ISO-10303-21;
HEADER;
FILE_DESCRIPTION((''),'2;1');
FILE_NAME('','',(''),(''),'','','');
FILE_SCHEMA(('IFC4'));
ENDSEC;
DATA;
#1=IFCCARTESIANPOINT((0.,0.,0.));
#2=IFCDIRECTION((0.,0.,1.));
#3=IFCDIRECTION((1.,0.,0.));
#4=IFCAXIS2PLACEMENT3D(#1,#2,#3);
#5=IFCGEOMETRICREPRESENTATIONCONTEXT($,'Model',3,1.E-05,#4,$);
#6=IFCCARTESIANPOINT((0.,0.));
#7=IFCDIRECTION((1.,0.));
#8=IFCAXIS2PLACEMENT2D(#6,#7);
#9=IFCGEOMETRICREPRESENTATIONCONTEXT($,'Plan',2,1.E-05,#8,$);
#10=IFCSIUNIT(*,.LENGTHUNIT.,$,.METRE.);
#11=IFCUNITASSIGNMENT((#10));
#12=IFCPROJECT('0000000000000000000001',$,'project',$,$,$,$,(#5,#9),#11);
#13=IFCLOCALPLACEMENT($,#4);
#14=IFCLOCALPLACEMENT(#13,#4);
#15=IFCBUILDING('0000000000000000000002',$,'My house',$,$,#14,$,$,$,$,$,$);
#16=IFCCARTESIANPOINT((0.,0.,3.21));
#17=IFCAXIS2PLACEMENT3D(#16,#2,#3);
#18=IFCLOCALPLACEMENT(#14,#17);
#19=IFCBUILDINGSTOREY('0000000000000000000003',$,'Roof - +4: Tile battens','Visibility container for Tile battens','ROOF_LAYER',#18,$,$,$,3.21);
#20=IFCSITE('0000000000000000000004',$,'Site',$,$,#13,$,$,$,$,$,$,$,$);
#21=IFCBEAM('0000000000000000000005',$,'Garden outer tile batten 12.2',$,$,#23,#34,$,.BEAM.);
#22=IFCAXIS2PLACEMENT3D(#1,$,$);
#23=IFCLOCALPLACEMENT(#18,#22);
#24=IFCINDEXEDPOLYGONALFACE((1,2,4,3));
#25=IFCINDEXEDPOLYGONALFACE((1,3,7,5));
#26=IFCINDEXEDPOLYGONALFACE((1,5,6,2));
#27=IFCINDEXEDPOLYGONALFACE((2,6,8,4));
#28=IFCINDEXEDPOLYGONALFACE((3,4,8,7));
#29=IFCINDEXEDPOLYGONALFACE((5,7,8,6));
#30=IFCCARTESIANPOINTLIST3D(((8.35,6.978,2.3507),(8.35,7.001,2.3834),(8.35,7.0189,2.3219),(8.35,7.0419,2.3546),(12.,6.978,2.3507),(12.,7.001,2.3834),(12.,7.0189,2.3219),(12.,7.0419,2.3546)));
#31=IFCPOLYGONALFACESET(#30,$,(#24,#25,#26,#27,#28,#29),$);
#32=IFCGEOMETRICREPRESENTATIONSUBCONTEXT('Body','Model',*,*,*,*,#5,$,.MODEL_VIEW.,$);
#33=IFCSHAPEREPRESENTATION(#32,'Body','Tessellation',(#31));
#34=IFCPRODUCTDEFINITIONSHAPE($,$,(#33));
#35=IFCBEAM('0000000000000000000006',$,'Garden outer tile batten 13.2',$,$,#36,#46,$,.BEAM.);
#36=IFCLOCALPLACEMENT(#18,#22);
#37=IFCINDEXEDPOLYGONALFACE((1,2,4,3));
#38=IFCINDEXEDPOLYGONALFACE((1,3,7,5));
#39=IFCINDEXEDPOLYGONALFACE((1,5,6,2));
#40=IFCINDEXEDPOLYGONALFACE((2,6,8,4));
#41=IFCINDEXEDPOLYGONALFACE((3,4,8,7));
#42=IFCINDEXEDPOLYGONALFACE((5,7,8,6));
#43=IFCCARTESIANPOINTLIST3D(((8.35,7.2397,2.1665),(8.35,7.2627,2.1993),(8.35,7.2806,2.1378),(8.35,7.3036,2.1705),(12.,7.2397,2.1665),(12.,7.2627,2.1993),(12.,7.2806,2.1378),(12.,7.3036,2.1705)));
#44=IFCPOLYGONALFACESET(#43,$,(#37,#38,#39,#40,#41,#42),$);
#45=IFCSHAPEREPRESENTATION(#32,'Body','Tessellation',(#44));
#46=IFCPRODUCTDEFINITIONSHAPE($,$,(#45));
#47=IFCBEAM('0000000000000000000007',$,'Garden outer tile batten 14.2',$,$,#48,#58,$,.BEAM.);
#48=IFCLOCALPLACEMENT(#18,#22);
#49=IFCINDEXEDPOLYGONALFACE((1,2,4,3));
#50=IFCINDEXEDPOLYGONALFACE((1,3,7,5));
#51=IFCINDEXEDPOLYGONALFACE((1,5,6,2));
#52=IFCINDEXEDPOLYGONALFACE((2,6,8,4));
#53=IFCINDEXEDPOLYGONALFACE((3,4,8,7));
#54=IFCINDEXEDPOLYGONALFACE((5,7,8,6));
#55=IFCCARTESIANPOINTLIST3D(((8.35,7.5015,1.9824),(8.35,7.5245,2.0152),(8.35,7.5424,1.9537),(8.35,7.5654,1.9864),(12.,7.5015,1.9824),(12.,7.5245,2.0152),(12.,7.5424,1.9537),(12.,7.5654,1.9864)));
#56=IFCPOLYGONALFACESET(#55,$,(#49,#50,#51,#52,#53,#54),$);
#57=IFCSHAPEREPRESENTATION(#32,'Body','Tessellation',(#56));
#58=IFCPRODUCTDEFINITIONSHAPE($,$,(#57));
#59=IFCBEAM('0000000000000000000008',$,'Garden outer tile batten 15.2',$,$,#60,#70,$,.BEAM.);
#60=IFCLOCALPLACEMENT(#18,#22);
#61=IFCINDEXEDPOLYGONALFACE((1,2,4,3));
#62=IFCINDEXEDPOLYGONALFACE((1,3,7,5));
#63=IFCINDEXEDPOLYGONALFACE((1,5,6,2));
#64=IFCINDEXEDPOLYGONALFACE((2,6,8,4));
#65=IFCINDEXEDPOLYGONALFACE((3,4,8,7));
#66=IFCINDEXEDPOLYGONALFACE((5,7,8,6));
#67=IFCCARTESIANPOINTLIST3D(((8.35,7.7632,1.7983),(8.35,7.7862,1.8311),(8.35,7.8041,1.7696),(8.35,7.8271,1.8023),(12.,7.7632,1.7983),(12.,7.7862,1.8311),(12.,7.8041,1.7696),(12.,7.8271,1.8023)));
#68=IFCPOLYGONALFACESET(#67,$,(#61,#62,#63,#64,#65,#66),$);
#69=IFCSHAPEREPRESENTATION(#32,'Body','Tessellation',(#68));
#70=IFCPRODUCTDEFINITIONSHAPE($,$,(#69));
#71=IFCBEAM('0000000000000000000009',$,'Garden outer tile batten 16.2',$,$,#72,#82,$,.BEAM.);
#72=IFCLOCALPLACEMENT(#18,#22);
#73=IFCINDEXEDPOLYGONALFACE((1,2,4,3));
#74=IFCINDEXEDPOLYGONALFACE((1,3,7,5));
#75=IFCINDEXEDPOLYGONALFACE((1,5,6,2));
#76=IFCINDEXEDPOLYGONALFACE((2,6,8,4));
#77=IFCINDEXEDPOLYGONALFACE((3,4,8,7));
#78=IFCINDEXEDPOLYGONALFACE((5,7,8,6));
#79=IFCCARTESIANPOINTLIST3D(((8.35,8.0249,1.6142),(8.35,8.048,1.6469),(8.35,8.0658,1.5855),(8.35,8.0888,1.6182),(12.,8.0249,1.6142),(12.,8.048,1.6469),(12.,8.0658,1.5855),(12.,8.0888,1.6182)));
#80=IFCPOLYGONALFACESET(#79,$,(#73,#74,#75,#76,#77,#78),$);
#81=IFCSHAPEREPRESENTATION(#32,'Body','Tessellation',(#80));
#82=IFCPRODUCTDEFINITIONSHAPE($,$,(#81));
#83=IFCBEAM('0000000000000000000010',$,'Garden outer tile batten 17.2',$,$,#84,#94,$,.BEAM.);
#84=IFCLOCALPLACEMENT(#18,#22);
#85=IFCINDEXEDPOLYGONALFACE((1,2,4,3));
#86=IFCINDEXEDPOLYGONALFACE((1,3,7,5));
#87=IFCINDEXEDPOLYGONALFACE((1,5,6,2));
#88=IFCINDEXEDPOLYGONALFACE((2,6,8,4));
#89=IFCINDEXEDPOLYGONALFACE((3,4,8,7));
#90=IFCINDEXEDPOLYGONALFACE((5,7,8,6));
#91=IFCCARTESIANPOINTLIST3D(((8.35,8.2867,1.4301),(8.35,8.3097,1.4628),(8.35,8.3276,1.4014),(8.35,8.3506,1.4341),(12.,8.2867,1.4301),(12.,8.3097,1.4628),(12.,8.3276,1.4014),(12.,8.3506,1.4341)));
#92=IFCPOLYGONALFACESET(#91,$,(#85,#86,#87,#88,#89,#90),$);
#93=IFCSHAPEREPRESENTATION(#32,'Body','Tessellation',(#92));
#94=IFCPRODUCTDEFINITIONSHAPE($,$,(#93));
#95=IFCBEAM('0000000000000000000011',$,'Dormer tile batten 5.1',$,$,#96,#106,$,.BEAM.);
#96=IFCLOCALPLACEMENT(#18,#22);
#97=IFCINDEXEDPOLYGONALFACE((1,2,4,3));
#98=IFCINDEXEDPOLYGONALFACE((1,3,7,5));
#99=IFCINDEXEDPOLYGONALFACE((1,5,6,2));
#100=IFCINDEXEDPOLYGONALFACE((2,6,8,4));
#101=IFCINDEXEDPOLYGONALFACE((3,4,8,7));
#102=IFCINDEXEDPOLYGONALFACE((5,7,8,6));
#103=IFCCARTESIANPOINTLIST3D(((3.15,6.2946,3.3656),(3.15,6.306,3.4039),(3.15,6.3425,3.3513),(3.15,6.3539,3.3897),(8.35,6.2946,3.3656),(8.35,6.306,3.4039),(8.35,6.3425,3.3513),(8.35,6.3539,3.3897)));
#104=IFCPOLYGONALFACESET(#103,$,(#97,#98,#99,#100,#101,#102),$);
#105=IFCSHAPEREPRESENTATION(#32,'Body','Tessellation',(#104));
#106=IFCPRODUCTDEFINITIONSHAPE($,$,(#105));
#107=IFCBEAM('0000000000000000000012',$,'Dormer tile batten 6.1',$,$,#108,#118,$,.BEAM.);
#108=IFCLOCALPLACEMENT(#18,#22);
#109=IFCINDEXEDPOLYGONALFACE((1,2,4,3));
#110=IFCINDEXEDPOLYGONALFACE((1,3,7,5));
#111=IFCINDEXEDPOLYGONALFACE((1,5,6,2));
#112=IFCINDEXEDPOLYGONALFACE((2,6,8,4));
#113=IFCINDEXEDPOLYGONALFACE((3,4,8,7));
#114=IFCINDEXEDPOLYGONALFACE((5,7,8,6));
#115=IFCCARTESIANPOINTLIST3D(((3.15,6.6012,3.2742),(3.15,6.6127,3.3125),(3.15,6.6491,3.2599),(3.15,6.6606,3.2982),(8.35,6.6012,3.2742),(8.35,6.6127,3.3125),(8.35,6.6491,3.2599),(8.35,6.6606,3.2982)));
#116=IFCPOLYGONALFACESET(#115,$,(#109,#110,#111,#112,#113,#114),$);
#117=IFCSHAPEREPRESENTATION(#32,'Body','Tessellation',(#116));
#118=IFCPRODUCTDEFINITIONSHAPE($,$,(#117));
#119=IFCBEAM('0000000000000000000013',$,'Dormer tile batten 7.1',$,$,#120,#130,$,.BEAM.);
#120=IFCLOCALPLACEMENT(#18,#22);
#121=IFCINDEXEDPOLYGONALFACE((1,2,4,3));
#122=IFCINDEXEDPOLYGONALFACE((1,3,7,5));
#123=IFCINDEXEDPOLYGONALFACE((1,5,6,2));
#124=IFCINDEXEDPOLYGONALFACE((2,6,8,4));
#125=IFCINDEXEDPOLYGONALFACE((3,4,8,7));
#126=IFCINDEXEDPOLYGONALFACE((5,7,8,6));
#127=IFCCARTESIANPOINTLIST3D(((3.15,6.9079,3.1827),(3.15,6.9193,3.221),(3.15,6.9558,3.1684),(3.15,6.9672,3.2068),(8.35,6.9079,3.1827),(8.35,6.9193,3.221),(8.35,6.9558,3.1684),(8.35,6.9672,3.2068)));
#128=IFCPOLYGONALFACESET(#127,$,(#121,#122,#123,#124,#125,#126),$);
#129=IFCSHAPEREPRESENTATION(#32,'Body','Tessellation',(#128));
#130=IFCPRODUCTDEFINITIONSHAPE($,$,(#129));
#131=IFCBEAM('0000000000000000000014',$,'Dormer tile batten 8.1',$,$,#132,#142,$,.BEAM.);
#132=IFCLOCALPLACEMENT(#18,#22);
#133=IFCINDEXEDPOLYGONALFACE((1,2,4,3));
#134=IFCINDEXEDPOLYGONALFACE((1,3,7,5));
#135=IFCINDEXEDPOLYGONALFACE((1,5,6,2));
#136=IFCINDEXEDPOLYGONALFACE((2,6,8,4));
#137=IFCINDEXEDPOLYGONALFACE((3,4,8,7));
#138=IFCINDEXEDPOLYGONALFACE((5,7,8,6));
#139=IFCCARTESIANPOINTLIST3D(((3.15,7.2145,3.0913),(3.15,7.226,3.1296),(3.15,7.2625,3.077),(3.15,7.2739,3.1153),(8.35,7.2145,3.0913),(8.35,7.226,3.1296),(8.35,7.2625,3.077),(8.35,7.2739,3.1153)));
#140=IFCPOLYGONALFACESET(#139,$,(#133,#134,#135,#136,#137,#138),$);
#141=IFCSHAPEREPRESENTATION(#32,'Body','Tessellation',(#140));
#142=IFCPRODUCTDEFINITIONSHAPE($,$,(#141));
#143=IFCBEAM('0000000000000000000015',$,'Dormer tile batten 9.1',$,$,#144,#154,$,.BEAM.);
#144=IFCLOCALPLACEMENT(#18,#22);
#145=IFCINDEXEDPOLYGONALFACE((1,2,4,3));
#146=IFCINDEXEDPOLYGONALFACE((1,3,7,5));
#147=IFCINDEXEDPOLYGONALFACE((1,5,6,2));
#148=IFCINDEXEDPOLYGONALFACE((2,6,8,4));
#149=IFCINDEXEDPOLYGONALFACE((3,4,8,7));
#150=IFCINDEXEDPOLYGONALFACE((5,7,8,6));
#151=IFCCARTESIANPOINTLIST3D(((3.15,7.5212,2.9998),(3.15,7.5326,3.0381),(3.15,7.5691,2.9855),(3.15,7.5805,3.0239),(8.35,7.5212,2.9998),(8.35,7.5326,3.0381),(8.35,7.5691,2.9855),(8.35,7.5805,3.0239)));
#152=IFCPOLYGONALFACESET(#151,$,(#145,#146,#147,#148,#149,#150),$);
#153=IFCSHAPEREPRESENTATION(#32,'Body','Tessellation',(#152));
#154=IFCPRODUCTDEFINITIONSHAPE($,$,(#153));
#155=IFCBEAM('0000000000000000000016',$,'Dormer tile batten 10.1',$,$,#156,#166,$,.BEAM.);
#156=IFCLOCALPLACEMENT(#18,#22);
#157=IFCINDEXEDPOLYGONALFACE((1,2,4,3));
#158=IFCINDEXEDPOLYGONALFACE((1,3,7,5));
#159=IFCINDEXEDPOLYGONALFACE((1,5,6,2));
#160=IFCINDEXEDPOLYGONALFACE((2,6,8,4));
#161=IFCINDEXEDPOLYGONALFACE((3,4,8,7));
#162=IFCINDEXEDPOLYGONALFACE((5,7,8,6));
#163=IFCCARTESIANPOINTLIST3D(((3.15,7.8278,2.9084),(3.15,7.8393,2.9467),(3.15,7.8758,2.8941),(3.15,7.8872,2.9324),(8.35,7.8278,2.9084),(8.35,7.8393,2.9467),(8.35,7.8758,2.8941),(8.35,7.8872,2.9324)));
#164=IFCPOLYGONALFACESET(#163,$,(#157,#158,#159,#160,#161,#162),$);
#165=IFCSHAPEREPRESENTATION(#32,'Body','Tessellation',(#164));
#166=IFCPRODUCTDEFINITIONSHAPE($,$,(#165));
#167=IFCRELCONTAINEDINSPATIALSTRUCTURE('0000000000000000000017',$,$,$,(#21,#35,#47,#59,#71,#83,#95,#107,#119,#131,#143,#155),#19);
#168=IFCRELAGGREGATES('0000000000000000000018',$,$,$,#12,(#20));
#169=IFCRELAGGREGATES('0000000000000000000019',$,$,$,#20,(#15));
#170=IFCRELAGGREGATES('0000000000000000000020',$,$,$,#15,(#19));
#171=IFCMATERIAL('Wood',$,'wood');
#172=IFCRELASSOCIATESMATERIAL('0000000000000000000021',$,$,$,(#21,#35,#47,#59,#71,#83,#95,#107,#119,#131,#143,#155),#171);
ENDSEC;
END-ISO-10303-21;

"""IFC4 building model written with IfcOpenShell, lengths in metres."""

from ifc_helpers import new_model, si_unit, frame, origin_with_axes, origin_2d_with_axis, place, context, subcontext, project, spatial, rectangle, extrude, clip, halfspace, material, element, save


model = new_model("IFC4")

# Units and contexts
model_context = context("Model", 3, precision=1e-05, world=origin_with_axes())
plan_context = context("Plan", 2, precision=1e-05, world=origin_2d_with_axis())
body_context = subcontext(model_context, "Body", "Model", "MODEL_VIEW")
ifc_project = project(units=[si_unit("LENGTHUNIT", "METRE")], contexts=[model_context, plan_context])

# Site, building, storey
site_placement = place(None, origin_with_axes())
site = spatial("IfcSite", under=ifc_project, at=site_placement, Name="Site")
building_placement = place(site_placement, origin_with_axes())
building = spatial("IfcBuilding", under=site, at=building_placement, Name="My house")
storey_placement = place(building_placement, frame((0.0, 0.0, 3.21), z_axis=(0.0, 0.0, 1.0), x_axis=(1.0, 0.0, 0.0)))
storey = spatial("IfcBuildingStorey", under=building, at=storey_placement, Name="Roof - +4: Tile battens", Description="Visibility container for Tile battens", ObjectType="ROOF_LAYER", Elevation=3.21)

# Beams
ifc_material = material(Name="Wood", Category="wood")
beam_1_placement = place(storey_placement, frame((8.35, 7.01, 2.3526), z_axis=(0.0, 0.575329, 0.817922), x_axis=(1.0, 0.0, 0.0)))
element("IfcBeam", 1, at=beam_1_placement, inside=storey, material=ifc_material, Name="Garden outer tile batten 12.2", PredefinedType="BEAM", context=body_context, shape_type="Clipping", body=[
    clip(clip(extrude(rectangle(XDim=0.05, YDim=0.04), frame((0.0, 0.0, 0.0), z_axis=(1.0, 0.0, 0.0), x_axis=(0.0, 1.0, 0.0)), (0.0, 0.0, 1.0), 3.65), halfspace(frame((-8.35, 0.7384, -6.2815), z_axis=(0.0, -0.817922, -0.575329), x_axis=(-1.0, 0.0, 0.0)), False)), halfspace(frame((-8.35, 4.3373, -3.7501), z_axis=(0.0, 0.817922, 0.575329), x_axis=(1.0, 0.0, 0.0)), False)),
])
beam_2_placement = place(storey_placement, frame((8.35, 7.2717, 2.1685), z_axis=(0.0, 0.575329, 0.817922), x_axis=(1.0, 0.0, 0.0)))
element("IfcBeam", 2, at=beam_2_placement, inside=storey, material=ifc_material, Name="Garden outer tile batten 13.2", PredefinedType="BEAM", context=body_context, shape_type="Clipping", body=[
    clip(clip(extrude(rectangle(XDim=0.05, YDim=0.04), frame((0.0, 0.0, 0.0), z_axis=(1.0, 0.0, 0.0), x_axis=(0.0, 1.0, 0.0)), (0.0, 0.0, 1.0), 3.65), halfspace(frame((-8.35, 0.4184, -6.2815), z_axis=(0.0, -0.817922, -0.575329), x_axis=(-1.0, 0.0, 0.0)), False)), halfspace(frame((-8.35, 4.0173, -3.7501), z_axis=(0.0, 0.817922, 0.575329), x_axis=(1.0, 0.0, 0.0)), False)),
])
beam_3_placement = place(storey_placement, frame((8.35, 7.5334, 1.9844), z_axis=(0.0, 0.575329, 0.817922), x_axis=(1.0, 0.0, 0.0)))
element("IfcBeam", 3, at=beam_3_placement, inside=storey, material=ifc_material, Name="Garden outer tile batten 14.2", PredefinedType="BEAM", context=body_context, shape_type="Clipping", body=[
    clip(clip(extrude(rectangle(XDim=0.05, YDim=0.04), frame((0.0, 0.0, 0.0), z_axis=(1.0, 0.0, 0.0), x_axis=(0.0, 1.0, 0.0)), (0.0, 0.0, 1.0), 3.65), halfspace(frame((-8.35, 0.0984, -6.2815), z_axis=(0.0, -0.817922, -0.575329), x_axis=(-1.0, 0.0, 0.0)), False)), halfspace(frame((-8.35, 3.6973, -3.7501), z_axis=(0.0, 0.817922, 0.575329), x_axis=(1.0, 0.0, 0.0)), False)),
])
beam_4_placement = place(storey_placement, frame((8.35, 7.7952, 1.8003), z_axis=(0.0, 0.575329, 0.817922), x_axis=(1.0, 0.0, 0.0)))
element("IfcBeam", 4, at=beam_4_placement, inside=storey, material=ifc_material, Name="Garden outer tile batten 15.2", PredefinedType="BEAM", context=body_context, shape_type="Clipping", body=[
    clip(clip(extrude(rectangle(XDim=0.05, YDim=0.04), frame((0.0, 0.0, 0.0), z_axis=(1.0, 0.0, 0.0), x_axis=(0.0, 1.0, 0.0)), (0.0, 0.0, 1.0), 3.65), halfspace(frame((-8.35, -0.2216, -6.2815), z_axis=(0.0, -0.817922, -0.575329), x_axis=(-1.0, 0.0, 0.0)), False)), halfspace(frame((-8.35, 3.3773, -3.7501), z_axis=(0.0, 0.817922, 0.575329), x_axis=(1.0, 0.0, 0.0)), False)),
])
beam_5_placement = place(storey_placement, frame((8.35, 8.0569, 1.6162), z_axis=(0.0, 0.575329, 0.817922), x_axis=(1.0, 0.0, 0.0)))
element("IfcBeam", 5, at=beam_5_placement, inside=storey, material=ifc_material, Name="Garden outer tile batten 16.2", PredefinedType="BEAM", context=body_context, shape_type="Clipping", body=[
    clip(clip(extrude(rectangle(XDim=0.05, YDim=0.04), frame((0.0, 0.0, 0.0), z_axis=(1.0, 0.0, 0.0), x_axis=(0.0, 1.0, 0.0)), (0.0, 0.0, 1.0), 3.65), halfspace(frame((-8.35, -0.5416, -6.2815), z_axis=(0.0, -0.817922, -0.575329), x_axis=(-1.0, 0.0, 0.0)), False)), halfspace(frame((-8.35, 3.0573, -3.7501), z_axis=(0.0, 0.817922, 0.575329), x_axis=(1.0, 0.0, 0.0)), False)),
])
beam_6_placement = place(storey_placement, frame((8.35, 8.3186, 1.4321), z_axis=(0.0, 0.575329, 0.817922), x_axis=(1.0, 0.0, 0.0)))
element("IfcBeam", 6, at=beam_6_placement, inside=storey, material=ifc_material, Name="Garden outer tile batten 17.2", PredefinedType="BEAM", context=body_context, shape_type="Clipping", body=[
    clip(clip(extrude(rectangle(XDim=0.05, YDim=0.04), frame((0.0, 0.0, 0.0), z_axis=(1.0, 0.0, 0.0), x_axis=(0.0, 1.0, 0.0)), (0.0, 0.0, 1.0), 3.65), halfspace(frame((-8.35, -0.8616, -6.2815), z_axis=(0.0, -0.817922, -0.575329), x_axis=(-1.0, 0.0, 0.0)), False)), halfspace(frame((-8.35, 2.7373, -3.7501), z_axis=(0.0, 0.817922, 0.575329), x_axis=(1.0, 0.0, 0.0)), False)),
])
beam_7_placement = place(storey_placement, frame((3.15, 6.3242, 3.3776), z_axis=(0.0, 0.28578, 0.958295), x_axis=(1.0, 0.0, 0.0)))
element("IfcBeam", 7, at=beam_7_placement, inside=storey, material=ifc_material, Name="Dormer tile batten 5.1", PredefinedType="BEAM", context=body_context, shape_type="Clipping", body=[
    clip(clip(extrude(rectangle(XDim=0.05, YDim=0.04), frame((0.0, 0.0, 0.0), z_axis=(1.0, 0.0, 0.0), x_axis=(0.0, 1.0, 0.0)), (0.0, 0.0, 1.0), 5.2), halfspace(frame((-3.15, -0.3447, -6.9771), z_axis=(0.0, -0.958295, -0.28578), x_axis=(-1.0, 0.0, 0.0)), False)), halfspace(frame((-3.15, 3.8718, -5.7197), z_axis=(0.0, 0.958295, 0.28578), x_axis=(1.0, 0.0, 0.0)), False)),
])
beam_8_placement = place(storey_placement, frame((3.15, 6.6309, 3.2862), z_axis=(0.0, 0.28578, 0.958295), x_axis=(1.0, 0.0, 0.0)))
element("IfcBeam", 8, at=beam_8_placement, inside=storey, material=ifc_material, Name="Dormer tile batten 6.1", PredefinedType="BEAM", context=body_context, shape_type="Clipping", body=[
    clip(clip(extrude(rectangle(XDim=0.05, YDim=0.04), frame((0.0, 0.0, 0.0), z_axis=(1.0, 0.0, 0.0), x_axis=(0.0, 1.0, 0.0)), (0.0, 0.0, 1.0), 5.2), halfspace(frame((-3.15, -0.6647, -6.9771), z_axis=(0.0, -0.958295, -0.28578), x_axis=(-1.0, 0.0, 0.0)), False)), halfspace(frame((-3.15, 3.5518, -5.7197), z_axis=(0.0, 0.958295, 0.28578), x_axis=(1.0, 0.0, 0.0)), False)),
])
beam_9_placement = place(storey_placement, frame((3.15, 6.9376, 3.1947), z_axis=(0.0, 0.28578, 0.958295), x_axis=(1.0, 0.0, 0.0)))
element("IfcBeam", 9, at=beam_9_placement, inside=storey, material=ifc_material, Name="Dormer tile batten 7.1", PredefinedType="BEAM", context=body_context, shape_type="Clipping", body=[
    clip(clip(extrude(rectangle(XDim=0.05, YDim=0.04), frame((0.0, 0.0, 0.0), z_axis=(1.0, 0.0, 0.0), x_axis=(0.0, 1.0, 0.0)), (0.0, 0.0, 1.0), 5.2), halfspace(frame((-3.15, -0.9847, -6.9771), z_axis=(0.0, -0.958295, -0.28578), x_axis=(-1.0, 0.0, 0.0)), False)), halfspace(frame((-3.15, 3.2318, -5.7197), z_axis=(0.0, 0.958295, 0.28578), x_axis=(1.0, 0.0, 0.0)), False)),
])
beam_10_placement = place(storey_placement, frame((3.15, 7.2442, 3.1033), z_axis=(0.0, 0.28578, 0.958295), x_axis=(1.0, 0.0, 0.0)))
element("IfcBeam", 10, at=beam_10_placement, inside=storey, material=ifc_material, Name="Dormer tile batten 8.1", PredefinedType="BEAM", context=body_context, shape_type="Clipping", body=[
    clip(clip(extrude(rectangle(XDim=0.05, YDim=0.04), frame((0.0, 0.0, 0.0), z_axis=(1.0, 0.0, 0.0), x_axis=(0.0, 1.0, 0.0)), (0.0, 0.0, 1.0), 5.2), halfspace(frame((-3.15, -1.3047, -6.9771), z_axis=(0.0, -0.958295, -0.28578), x_axis=(-1.0, 0.0, 0.0)), False)), halfspace(frame((-3.15, 2.9118, -5.7197), z_axis=(0.0, 0.958295, 0.28578), x_axis=(1.0, 0.0, 0.0)), False)),
])
beam_11_placement = place(storey_placement, frame((3.15, 7.5509, 3.0118), z_axis=(0.0, 0.28578, 0.958295), x_axis=(1.0, 0.0, 0.0)))
element("IfcBeam", 11, at=beam_11_placement, inside=storey, material=ifc_material, Name="Dormer tile batten 9.1", PredefinedType="BEAM", context=body_context, shape_type="Clipping", body=[
    clip(clip(extrude(rectangle(XDim=0.05, YDim=0.04), frame((0.0, 0.0, 0.0), z_axis=(1.0, 0.0, 0.0), x_axis=(0.0, 1.0, 0.0)), (0.0, 0.0, 1.0), 5.2), halfspace(frame((-3.15, -1.6247, -6.9771), z_axis=(0.0, -0.958295, -0.28578), x_axis=(-1.0, 0.0, 0.0)), False)), halfspace(frame((-3.15, 2.5918, -5.7197), z_axis=(0.0, 0.958295, 0.28578), x_axis=(1.0, 0.0, 0.0)), False)),
])
beam_12_placement = place(storey_placement, frame((3.15, 7.8575, 2.9204), z_axis=(0.0, 0.28578, 0.958295), x_axis=(1.0, 0.0, 0.0)))
element("IfcBeam", 12, at=beam_12_placement, inside=storey, material=ifc_material, Name="Dormer tile batten 10.1", PredefinedType="BEAM", context=body_context, shape_type="Clipping", body=[
    clip(clip(extrude(rectangle(XDim=0.05, YDim=0.04), frame((0.0, 0.0, 0.0), z_axis=(1.0, 0.0, 0.0), x_axis=(0.0, 1.0, 0.0)), (0.0, 0.0, 1.0), 5.2), halfspace(frame((-3.15, -1.9447, -6.9771), z_axis=(0.0, -0.958295, -0.28578), x_axis=(-1.0, 0.0, 0.0)), False)), halfspace(frame((-3.15, 2.2718, -5.7197), z_axis=(0.0, 0.958295, 0.28578), x_axis=(1.0, 0.0, 0.0)), False)),
])

save(model, "model.ifc")
